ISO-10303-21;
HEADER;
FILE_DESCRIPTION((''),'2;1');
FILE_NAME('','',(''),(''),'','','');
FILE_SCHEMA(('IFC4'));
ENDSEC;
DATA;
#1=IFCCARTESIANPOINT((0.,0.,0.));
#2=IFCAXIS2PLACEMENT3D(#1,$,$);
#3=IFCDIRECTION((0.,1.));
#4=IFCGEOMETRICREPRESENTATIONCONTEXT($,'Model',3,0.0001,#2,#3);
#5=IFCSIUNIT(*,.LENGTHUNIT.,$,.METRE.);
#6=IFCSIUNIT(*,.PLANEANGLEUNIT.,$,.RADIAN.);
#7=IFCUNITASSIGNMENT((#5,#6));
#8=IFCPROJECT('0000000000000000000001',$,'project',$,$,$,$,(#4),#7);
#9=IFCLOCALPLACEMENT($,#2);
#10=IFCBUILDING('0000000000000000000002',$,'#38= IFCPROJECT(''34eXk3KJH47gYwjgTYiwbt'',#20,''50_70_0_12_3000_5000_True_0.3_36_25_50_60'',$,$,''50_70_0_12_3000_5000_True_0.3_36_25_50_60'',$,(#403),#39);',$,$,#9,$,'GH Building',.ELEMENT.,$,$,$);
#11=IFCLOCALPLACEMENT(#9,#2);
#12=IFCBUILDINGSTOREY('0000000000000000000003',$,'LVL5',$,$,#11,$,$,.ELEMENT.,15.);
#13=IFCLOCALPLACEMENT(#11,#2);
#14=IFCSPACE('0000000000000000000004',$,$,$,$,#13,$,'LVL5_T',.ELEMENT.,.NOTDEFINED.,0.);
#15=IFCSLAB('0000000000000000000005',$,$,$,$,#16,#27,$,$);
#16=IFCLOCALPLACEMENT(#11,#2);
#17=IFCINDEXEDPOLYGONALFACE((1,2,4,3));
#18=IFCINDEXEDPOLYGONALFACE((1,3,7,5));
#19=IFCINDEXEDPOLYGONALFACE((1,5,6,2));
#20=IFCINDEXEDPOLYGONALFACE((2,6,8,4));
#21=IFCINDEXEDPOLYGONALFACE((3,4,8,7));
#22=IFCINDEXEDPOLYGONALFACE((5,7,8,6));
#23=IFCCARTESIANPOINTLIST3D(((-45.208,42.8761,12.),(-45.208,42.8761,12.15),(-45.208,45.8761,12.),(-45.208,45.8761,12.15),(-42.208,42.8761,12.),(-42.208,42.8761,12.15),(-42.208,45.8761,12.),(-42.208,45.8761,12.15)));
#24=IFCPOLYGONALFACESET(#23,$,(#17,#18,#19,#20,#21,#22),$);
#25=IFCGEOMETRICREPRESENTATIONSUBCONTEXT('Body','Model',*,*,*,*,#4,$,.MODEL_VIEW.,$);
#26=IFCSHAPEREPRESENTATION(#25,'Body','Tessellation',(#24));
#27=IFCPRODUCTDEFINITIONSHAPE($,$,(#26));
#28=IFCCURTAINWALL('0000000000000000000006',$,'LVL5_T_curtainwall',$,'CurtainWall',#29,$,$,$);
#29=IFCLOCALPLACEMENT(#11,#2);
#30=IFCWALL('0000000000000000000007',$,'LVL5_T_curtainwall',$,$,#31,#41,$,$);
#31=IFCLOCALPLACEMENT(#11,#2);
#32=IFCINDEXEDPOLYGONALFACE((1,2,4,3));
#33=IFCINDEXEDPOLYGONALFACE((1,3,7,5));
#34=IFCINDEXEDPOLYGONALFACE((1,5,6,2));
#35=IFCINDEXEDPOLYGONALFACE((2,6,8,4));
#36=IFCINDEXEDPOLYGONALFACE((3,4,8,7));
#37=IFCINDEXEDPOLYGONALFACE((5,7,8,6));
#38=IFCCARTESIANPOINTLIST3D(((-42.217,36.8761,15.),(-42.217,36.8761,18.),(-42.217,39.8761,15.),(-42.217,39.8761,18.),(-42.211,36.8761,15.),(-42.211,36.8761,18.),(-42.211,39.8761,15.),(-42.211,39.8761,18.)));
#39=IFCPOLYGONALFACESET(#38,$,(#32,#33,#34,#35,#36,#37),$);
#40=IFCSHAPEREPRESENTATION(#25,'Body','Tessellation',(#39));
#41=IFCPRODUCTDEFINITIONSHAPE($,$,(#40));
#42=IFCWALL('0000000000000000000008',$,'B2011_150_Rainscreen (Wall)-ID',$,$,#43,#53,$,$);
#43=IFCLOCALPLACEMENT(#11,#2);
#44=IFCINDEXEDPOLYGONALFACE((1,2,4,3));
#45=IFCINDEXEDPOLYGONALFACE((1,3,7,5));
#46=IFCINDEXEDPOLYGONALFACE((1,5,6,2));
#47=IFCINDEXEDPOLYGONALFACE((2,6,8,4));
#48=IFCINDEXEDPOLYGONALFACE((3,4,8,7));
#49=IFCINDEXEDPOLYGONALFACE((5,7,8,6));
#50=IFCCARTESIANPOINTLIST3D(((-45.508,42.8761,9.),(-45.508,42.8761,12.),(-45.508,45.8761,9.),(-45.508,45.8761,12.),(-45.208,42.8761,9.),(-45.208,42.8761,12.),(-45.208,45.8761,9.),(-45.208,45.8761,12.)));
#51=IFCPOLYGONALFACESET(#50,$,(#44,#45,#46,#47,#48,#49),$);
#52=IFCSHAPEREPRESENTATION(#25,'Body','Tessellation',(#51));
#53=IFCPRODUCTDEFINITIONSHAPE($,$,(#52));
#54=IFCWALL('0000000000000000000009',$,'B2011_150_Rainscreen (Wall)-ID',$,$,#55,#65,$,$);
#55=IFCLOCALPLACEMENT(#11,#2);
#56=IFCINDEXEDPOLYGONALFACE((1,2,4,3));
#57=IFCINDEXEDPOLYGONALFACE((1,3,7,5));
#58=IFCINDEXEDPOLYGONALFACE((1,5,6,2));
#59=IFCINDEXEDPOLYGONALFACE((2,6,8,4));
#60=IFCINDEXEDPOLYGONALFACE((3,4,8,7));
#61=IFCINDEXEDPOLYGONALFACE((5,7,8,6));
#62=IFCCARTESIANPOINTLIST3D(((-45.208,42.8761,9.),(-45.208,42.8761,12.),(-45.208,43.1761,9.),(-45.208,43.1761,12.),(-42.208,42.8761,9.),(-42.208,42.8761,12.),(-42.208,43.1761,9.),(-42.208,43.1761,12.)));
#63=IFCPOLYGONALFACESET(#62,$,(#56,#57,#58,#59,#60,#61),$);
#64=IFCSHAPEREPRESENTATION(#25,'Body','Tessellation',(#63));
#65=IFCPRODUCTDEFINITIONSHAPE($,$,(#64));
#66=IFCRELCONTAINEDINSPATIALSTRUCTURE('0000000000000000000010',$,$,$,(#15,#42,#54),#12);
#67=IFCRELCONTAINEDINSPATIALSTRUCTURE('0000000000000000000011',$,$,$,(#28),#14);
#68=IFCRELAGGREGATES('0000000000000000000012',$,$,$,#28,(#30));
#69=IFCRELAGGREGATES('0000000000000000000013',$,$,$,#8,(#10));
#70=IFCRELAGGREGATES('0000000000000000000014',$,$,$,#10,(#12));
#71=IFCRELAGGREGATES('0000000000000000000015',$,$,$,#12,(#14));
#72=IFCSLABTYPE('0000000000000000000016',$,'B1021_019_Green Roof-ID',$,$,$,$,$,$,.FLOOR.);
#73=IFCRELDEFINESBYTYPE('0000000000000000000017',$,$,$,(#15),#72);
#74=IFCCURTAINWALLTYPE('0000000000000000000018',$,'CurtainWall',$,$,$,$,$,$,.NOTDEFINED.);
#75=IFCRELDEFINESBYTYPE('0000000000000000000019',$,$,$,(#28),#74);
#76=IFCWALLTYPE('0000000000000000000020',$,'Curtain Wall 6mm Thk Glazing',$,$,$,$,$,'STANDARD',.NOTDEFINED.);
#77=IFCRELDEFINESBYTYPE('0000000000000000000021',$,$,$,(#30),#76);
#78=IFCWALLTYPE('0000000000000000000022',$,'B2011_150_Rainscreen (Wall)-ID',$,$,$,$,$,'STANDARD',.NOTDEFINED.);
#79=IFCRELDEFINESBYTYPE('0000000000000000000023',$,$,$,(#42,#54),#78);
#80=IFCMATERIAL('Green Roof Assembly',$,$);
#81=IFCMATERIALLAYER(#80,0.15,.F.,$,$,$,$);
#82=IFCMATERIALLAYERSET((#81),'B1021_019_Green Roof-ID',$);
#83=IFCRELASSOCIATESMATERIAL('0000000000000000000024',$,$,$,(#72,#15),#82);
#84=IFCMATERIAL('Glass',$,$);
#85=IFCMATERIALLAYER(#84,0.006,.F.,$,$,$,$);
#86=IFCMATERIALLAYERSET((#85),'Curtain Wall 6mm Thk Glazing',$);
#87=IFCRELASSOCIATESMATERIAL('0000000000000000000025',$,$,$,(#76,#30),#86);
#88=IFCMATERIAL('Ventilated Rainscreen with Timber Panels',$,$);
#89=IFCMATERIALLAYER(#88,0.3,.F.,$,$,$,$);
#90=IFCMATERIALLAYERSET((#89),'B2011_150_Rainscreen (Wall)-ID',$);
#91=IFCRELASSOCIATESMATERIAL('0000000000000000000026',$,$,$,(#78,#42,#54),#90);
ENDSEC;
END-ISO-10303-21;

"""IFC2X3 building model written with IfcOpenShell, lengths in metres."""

from ifc_helpers import new_model, si_unit, direction, frame, frame_2d, origin, place, context, subcontext, project, spatial, polyline, rectangle, outline, extrude, material, layer, layer_set, layer_usage, type_object, element, aggregate, save


model = new_model("IFC2X3")

# Units and contexts
model_context = context("Model", 3, precision=0.0001, world=origin(), true_north=direction((0.0, 1.0)))
body_context = subcontext(model_context, "Body", "Model", "MODEL_VIEW")
ifc_project = project(units=[si_unit("LENGTHUNIT", "METRE"), si_unit("PLANEANGLEUNIT", "RADIAN")], contexts=[model_context])

# Building, storey, space
building_placement = place(None, origin())
building = spatial("IfcBuilding", under=ifc_project, at=building_placement, Name="#38= IFCPROJECT('34eXk3KJH47gYwjgTYiwbt',#20,'50_70_0_12_3000_5000_True_0.3_36_25_50_60',$,$,'50_70_0_12_3000_5000_True_0.3_36_25_50_60',$,(#403),#39);", LongName="GH Building", CompositionType="ELEMENT")
storey_placement = place(building_placement, origin())
storey = spatial("IfcBuildingStorey", under=building, at=storey_placement, Name="LVL5", CompositionType="ELEMENT", Elevation=15.0)
space_1_placement = place(storey_placement, origin())
space_1 = spatial("IfcSpace", under=storey, at=space_1_placement, LongName="LVL5_T", CompositionType="ELEMENT", InteriorOrExteriorSpace="NOTDEFINED", ElevationWithFlooring=0.0)

# Slab
ifc_material_1 = material(Name="Green Roof Assembly")
ifc_layer_1 = layer(ifc_material_1, 0.15, ventilated=False)
ifc_layer_set_1 = layer_set([ifc_layer_1], Name="B1021_019_Green Roof-ID")
ifc_layer_usage_1 = layer_usage(ifc_layer_set_1, "AXIS3", "NEGATIVE", -0.15)
slab_type_1 = type_object("IfcSlabType", Name="B1021_019_Green Roof-ID", PredefinedType="FLOOR", material=ifc_layer_set_1)
slab_1_placement = place(storey_placement, frame((-43.708, 44.3761, 12.0)))
element("IfcSlab", 1, at=slab_1_placement, inside=storey, type_object=slab_type_1, material=ifc_layer_usage_1, context=body_context, shape_type="SweptSolid", body=[
    extrude(outline(polyline([(-1.5, 1.5), (1.5, 1.5), (1.5, -1.5), (-1.5, -1.5), (-1.5, 1.5)])), origin(), (0.0, 0.0, 1.0), 0.15),
])

# Curtain wall, wall
curtain_wall_type = type_object("IfcCurtainWallType", Name="CurtainWall", PredefinedType="NOTDEFINED")
curtain_wall_1_placement = place(None, origin())
curtain_wall_1 = element("IfcCurtainWall", 2, at=curtain_wall_1_placement, inside=space_1, type_object=curtain_wall_type, Name="LVL5_T_curtainwall", ObjectType="CurtainWall")
ifc_material_2 = material(Name="Glass")
ifc_layer_2 = layer(ifc_material_2, 0.006, ventilated=False)
ifc_layer_set_2 = layer_set([ifc_layer_2], Name="Curtain Wall 6mm Thk Glazing")
ifc_layer_usage_2 = layer_usage(ifc_layer_set_2, "AXIS2", "NEGATIVE", -0.003)
wall_type_1 = type_object("IfcWallType", Name="Curtain Wall 6mm Thk Glazing", ElementType="STANDARD", PredefinedType="NOTDEFINED", material=ifc_layer_set_2)
wall_1_placement = place(curtain_wall_1_placement, frame((-42.208, 39.8761, 15.0), z_axis=(0.0, 0.0, 1.0), x_axis=(0.0, -1.0, 0.0)))
wall_1 = element("IfcWall", 3, at=wall_1_placement, type_object=wall_type_1, material=ifc_layer_usage_2, Name="LVL5_T_curtainwall", context=body_context, shape_type="SweptSolid", body=[
    extrude(rectangle(XDim=3.0, YDim=0.006, at=frame_2d((1.5, -0.006))), origin(), (0.0, 0.0, 1.0), 3.0),
])
aggregate(curtain_wall_1, [wall_1])

# Walls
ifc_material_3 = material(Name="Ventilated Rainscreen with Timber Panels")
ifc_layer_3 = layer(ifc_material_3, 0.3, ventilated=False)
ifc_layer_set_3 = layer_set([ifc_layer_3], Name="B2011_150_Rainscreen (Wall)-ID")
ifc_layer_usage_3 = layer_usage(ifc_layer_set_3, "AXIS2", "POSITIVE", 0.0)
wall_type_2 = type_object("IfcWallType", Name="B2011_150_Rainscreen (Wall)-ID", ElementType="STANDARD", PredefinedType="NOTDEFINED", material=ifc_layer_set_3)
wall_2_placement = place(storey_placement, frame((-45.208, 42.8761, 9.0), z_axis=(0.0, 0.0, 1.0), x_axis=(0.0, 1.0, 0.0)))
element("IfcWall", 4, at=wall_2_placement, inside=storey, type_object=wall_type_2, material=ifc_layer_usage_3, Name="B2011_150_Rainscreen (Wall)-ID", context=body_context, shape_type="SweptSolid", body=[
    extrude(rectangle(XDim=3.0, YDim=0.3, at=frame_2d((1.5, 0.15))), origin(), (0.0, 0.0, 1.0), 3.0),
])
ifc_layer_usage_4 = layer_usage(ifc_layer_set_3, "AXIS2", "POSITIVE", 0.0)
wall_3_placement = place(storey_placement, frame((-45.208, 42.8761, 9.0)))
element("IfcWall", 5, at=wall_3_placement, inside=storey, type_object=wall_type_2, material=ifc_layer_usage_4, Name="B2011_150_Rainscreen (Wall)-ID", context=body_context, shape_type="SweptSolid", body=[
    extrude(rectangle(XDim=3.0, YDim=0.3, at=frame_2d((1.5, 0.15))), origin(), (0.0, 0.0, 1.0), 3.0),
])

save(model, "model.ifc")
